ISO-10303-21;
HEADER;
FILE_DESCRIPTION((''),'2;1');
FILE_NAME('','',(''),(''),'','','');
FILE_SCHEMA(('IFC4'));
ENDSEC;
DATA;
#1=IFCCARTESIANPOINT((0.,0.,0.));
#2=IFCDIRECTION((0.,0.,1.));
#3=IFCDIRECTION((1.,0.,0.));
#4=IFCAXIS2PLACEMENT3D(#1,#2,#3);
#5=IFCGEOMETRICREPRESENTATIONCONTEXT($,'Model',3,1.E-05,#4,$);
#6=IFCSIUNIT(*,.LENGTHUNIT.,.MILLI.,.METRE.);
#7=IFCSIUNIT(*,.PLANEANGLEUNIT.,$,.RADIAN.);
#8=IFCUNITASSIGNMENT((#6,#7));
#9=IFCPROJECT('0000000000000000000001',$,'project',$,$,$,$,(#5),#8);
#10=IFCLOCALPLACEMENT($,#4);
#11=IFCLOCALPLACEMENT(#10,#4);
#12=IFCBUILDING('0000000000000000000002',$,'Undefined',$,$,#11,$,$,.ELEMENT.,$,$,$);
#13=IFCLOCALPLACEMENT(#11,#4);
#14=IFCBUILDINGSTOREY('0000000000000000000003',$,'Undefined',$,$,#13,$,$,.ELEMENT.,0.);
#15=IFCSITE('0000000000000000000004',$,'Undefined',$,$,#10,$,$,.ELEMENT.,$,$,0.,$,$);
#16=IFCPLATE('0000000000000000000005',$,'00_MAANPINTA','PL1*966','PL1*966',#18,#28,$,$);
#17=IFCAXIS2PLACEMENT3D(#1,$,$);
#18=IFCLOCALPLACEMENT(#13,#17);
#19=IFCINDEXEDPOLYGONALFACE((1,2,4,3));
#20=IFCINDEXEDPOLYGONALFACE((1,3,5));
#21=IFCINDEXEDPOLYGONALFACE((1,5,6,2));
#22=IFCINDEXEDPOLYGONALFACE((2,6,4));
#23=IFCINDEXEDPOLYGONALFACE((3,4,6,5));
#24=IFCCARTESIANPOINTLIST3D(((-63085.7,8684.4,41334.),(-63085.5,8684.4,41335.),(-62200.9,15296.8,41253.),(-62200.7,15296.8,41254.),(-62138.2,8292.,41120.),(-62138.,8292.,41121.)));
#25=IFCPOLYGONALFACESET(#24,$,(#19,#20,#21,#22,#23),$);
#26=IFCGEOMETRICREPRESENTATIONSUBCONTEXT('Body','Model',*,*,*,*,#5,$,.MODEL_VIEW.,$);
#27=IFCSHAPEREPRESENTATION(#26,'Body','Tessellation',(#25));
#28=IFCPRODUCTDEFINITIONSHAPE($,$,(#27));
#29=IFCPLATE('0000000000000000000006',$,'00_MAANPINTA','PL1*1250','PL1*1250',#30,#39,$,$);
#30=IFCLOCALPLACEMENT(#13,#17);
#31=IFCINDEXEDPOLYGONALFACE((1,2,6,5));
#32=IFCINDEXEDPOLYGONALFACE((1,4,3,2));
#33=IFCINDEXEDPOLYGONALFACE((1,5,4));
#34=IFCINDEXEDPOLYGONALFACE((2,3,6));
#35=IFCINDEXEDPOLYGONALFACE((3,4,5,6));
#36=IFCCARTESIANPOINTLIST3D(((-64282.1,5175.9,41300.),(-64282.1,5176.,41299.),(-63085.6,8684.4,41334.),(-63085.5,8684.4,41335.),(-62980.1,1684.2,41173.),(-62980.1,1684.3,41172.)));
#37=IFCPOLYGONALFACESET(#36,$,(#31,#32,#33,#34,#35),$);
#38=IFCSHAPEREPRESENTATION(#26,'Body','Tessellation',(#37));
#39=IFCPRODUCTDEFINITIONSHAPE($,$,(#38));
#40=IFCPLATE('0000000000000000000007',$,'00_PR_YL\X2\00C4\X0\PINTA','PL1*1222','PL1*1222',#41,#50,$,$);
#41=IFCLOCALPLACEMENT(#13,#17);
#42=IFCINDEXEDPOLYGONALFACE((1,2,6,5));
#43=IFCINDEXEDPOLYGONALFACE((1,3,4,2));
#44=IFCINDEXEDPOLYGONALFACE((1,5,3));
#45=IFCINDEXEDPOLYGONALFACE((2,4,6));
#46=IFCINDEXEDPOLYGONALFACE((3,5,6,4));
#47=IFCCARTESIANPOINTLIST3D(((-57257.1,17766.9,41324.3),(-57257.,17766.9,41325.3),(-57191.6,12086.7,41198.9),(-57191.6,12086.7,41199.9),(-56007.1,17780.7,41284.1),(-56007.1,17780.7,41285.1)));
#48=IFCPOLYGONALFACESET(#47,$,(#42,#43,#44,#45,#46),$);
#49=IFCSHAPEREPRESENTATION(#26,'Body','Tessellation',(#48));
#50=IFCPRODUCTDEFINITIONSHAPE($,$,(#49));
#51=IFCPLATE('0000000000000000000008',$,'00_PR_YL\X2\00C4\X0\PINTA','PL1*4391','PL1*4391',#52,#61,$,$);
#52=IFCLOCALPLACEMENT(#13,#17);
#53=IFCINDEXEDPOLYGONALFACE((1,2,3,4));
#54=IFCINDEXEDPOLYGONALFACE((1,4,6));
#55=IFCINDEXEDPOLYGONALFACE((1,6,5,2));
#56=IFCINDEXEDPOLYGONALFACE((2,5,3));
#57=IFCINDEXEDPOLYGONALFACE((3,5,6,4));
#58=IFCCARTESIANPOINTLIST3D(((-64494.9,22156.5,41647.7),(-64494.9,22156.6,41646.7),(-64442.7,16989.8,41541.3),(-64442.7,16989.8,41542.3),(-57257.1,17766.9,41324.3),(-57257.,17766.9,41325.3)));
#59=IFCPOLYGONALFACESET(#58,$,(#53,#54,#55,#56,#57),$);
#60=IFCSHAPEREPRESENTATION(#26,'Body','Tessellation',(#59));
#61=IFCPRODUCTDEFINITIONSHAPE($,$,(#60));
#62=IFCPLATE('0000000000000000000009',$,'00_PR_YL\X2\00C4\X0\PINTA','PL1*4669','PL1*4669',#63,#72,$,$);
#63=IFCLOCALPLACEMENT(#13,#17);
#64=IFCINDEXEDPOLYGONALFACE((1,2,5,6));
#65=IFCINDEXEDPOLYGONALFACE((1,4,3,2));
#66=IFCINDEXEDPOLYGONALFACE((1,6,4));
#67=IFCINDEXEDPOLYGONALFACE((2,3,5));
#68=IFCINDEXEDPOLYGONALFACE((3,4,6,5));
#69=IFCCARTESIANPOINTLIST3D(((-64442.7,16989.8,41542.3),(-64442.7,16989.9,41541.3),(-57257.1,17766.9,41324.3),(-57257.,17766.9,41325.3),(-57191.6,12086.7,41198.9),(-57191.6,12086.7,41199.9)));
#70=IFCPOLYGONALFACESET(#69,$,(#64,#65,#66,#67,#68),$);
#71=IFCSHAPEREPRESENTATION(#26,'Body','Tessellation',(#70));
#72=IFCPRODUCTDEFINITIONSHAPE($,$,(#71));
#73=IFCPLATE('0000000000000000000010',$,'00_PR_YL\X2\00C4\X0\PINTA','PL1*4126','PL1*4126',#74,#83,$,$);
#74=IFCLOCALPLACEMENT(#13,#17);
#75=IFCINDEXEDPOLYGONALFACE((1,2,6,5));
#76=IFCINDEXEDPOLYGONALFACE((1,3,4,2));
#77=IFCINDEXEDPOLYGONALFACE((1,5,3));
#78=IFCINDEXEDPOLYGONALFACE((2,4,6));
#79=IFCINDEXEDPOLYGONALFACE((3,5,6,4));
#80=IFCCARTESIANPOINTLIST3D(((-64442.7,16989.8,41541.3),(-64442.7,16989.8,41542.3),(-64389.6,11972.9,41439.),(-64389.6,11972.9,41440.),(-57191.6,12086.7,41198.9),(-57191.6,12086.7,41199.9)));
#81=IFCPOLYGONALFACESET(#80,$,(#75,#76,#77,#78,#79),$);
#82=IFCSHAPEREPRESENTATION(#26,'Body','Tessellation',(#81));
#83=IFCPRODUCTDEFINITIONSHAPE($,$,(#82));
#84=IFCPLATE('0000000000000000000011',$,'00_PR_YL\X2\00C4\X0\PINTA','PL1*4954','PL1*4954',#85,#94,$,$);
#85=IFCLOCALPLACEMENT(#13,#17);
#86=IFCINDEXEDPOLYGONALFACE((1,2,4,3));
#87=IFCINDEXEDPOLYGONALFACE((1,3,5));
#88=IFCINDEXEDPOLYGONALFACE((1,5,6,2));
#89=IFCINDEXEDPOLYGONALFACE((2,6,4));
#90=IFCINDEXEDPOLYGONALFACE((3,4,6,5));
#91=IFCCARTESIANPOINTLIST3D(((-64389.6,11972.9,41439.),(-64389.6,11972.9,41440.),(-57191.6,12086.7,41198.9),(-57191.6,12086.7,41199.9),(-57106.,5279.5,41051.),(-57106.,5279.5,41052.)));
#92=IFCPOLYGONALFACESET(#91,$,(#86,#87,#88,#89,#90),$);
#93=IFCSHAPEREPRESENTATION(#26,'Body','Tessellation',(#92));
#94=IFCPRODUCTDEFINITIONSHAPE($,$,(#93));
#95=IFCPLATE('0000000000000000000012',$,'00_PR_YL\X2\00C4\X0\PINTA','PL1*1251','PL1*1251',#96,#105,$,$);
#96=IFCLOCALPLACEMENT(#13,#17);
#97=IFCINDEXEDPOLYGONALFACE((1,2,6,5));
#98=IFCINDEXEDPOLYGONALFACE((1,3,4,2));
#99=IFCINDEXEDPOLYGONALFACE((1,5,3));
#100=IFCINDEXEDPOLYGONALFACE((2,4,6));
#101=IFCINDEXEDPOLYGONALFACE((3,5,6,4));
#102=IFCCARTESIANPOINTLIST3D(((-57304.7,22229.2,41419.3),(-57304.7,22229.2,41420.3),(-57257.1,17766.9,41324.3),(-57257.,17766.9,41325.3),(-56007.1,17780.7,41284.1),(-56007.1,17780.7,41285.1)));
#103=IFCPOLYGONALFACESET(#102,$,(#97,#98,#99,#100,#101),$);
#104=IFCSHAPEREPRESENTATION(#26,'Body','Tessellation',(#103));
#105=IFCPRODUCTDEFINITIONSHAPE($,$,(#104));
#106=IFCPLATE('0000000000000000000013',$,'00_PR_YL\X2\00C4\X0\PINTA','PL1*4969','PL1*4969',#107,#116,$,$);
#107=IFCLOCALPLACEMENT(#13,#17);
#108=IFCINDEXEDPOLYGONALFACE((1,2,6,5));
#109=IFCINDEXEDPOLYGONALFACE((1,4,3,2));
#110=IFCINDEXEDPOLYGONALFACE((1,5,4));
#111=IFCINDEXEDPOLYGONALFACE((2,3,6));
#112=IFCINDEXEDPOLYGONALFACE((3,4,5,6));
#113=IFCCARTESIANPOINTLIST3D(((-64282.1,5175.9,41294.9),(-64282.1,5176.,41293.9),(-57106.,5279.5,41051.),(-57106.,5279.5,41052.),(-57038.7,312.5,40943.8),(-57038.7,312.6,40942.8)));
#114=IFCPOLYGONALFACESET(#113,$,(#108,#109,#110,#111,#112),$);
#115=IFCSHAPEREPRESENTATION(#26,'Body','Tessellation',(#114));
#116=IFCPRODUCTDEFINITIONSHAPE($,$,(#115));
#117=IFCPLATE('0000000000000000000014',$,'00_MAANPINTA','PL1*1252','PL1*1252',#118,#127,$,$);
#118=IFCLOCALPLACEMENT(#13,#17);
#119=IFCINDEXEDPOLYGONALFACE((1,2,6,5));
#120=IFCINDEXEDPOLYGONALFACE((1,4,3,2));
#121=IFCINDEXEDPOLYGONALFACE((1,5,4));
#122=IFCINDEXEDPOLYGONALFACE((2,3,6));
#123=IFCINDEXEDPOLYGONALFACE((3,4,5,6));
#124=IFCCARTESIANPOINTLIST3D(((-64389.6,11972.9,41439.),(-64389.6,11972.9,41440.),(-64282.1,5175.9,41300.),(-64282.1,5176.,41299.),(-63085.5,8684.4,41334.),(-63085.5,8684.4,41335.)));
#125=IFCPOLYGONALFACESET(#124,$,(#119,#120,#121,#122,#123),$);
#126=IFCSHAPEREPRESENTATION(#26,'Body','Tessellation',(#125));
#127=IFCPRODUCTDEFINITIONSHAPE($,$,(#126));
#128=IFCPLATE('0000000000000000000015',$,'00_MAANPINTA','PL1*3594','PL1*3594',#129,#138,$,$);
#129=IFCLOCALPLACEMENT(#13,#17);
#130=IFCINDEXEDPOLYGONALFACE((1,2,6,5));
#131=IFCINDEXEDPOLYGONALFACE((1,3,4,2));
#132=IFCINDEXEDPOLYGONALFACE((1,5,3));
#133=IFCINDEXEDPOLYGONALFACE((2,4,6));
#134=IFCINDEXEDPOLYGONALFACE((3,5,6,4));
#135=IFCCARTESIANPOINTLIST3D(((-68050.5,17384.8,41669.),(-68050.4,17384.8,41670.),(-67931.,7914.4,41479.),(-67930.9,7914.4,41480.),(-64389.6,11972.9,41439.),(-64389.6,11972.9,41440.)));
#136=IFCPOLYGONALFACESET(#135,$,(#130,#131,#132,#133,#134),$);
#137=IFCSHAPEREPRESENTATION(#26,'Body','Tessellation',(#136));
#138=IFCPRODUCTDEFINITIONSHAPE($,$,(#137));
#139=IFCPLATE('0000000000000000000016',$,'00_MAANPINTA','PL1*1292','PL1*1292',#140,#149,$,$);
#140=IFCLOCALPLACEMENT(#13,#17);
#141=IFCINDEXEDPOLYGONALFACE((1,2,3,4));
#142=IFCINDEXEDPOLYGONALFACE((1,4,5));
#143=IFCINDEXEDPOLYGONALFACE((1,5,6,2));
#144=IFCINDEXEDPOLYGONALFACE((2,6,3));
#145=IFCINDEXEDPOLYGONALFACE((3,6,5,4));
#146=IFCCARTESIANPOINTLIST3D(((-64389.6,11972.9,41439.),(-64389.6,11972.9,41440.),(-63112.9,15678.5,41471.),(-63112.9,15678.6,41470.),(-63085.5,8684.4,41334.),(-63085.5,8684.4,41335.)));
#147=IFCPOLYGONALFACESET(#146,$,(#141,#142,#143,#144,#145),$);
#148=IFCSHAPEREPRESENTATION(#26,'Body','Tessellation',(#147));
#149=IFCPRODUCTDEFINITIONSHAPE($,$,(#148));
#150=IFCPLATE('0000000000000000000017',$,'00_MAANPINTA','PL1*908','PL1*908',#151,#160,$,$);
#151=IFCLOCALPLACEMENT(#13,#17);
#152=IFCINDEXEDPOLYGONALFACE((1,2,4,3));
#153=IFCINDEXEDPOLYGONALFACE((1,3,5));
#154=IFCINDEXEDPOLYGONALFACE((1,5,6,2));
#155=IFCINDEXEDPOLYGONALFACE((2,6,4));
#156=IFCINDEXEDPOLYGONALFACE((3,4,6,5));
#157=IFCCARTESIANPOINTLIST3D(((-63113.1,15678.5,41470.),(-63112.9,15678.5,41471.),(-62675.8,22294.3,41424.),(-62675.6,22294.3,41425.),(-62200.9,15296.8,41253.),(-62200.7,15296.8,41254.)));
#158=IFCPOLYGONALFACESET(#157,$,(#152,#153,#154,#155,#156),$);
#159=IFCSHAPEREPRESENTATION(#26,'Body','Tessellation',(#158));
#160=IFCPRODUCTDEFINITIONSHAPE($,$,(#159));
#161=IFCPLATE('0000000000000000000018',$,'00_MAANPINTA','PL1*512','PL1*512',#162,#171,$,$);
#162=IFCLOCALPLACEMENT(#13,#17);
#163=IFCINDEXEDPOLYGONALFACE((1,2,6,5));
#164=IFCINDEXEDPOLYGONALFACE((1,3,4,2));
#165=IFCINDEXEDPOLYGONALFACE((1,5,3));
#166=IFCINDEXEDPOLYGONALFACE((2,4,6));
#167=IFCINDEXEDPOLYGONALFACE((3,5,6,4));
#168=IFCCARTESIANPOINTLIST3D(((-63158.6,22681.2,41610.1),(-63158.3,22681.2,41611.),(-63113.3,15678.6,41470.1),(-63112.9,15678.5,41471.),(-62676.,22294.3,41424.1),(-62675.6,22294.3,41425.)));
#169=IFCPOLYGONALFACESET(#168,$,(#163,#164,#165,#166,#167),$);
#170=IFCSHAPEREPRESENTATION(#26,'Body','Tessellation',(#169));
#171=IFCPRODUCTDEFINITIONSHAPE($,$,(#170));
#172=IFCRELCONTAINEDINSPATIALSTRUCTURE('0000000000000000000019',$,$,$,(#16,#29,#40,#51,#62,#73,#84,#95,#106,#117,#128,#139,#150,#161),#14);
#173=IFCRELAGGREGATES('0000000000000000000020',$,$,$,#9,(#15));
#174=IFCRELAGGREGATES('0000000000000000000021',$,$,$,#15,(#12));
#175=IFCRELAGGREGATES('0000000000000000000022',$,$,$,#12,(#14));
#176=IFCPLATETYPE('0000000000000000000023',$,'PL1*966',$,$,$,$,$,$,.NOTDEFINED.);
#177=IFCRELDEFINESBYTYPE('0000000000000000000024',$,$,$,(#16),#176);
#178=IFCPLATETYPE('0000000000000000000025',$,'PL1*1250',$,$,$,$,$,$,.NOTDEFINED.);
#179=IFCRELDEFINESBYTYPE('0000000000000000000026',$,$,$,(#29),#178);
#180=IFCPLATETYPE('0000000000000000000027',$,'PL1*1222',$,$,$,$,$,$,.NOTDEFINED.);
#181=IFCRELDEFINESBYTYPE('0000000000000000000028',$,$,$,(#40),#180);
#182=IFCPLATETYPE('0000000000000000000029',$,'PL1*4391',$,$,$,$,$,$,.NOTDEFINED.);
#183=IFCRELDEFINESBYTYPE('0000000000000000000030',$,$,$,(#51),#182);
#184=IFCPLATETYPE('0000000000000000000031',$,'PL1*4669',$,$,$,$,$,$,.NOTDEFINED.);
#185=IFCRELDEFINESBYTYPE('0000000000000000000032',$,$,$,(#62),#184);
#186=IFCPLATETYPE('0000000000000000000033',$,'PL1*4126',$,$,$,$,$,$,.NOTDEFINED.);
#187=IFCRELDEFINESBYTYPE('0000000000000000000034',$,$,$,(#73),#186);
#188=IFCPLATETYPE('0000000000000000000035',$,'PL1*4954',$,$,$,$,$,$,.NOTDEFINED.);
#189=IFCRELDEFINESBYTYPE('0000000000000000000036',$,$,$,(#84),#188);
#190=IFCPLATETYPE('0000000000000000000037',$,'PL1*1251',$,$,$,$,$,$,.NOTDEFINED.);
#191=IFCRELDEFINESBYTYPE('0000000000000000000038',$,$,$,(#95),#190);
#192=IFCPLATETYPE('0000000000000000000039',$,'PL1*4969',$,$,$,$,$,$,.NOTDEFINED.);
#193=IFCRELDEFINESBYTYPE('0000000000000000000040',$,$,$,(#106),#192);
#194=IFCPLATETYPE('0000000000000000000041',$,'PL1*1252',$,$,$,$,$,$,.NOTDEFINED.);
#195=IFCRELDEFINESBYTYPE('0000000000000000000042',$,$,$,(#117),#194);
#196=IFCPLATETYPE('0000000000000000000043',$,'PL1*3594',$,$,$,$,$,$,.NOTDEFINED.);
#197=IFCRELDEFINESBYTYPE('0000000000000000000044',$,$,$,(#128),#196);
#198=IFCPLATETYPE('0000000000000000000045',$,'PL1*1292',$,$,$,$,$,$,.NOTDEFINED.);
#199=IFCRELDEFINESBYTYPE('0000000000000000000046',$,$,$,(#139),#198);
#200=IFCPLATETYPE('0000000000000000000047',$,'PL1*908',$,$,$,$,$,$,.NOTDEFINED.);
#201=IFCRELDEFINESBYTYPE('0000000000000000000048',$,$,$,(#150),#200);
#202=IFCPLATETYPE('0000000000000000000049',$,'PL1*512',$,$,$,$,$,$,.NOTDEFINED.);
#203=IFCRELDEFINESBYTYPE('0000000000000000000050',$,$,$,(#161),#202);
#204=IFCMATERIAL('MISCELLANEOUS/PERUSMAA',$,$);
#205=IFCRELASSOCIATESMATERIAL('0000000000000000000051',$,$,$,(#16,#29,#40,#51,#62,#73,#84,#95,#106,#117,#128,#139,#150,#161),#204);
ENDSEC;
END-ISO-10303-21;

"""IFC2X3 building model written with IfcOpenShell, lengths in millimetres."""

from ifc_helpers import new_model, si_unit, frame, origin_with_axes, place, context, subcontext, project, spatial, polyline, outline, extrude, material, type_object, element, save


model = new_model("IFC2X3")

# Units and contexts
model_context = context("Model", 3, precision=1e-05, world=origin_with_axes())
body_context = subcontext(model_context, "Body", "Model", "MODEL_VIEW")
ifc_project = project(units=[si_unit("LENGTHUNIT", "METRE", prefix="MILLI"), si_unit("PLANEANGLEUNIT", "RADIAN")], contexts=[model_context])

# Site, building, storey
site_placement = place(None, origin_with_axes())
site = spatial("IfcSite", under=ifc_project, at=site_placement, Name="Undefined", CompositionType="ELEMENT", RefElevation=0.0)
building_placement = place(site_placement, origin_with_axes())
building = spatial("IfcBuilding", under=site, at=building_placement, Name="Undefined", CompositionType="ELEMENT")
storey_placement = place(building_placement, origin_with_axes())
storey = spatial("IfcBuildingStorey", under=building, at=storey_placement, Name="Undefined", CompositionType="ELEMENT", Elevation=0.0)

# Plates
ifc_material = material(Name="MISCELLANEOUS/PERUSMAA")
plate_type_1 = type_object("IfcPlateType", Name="PL1*966", PredefinedType="NOTDEFINED")
plate_1_placement = place(storey_placement, frame((-62138.1, 8292.0, 41120.5), z_axis=(-0.213706, 0.016633, -0.976757), x_axis=(-0.904445, 0.374508, 0.204262)))
element("IfcPlate", 1, at=plate_1_placement, inside=storey, type_object=plate_type_1, material=ifc_material, Name="00_MAANPINTA", Description="PL1*966", ObjectType="PL1*966", context=body_context, shape_type="SweptSolid", body=[
    extrude(outline(polyline([(0.0, 0.0), (1047.7, 0.0), (2707.2, 6462.2), (0.0, 0.0)])), frame((0.0, 0.0, -0.5), z_axis=(0.0, 0.0, 1.0), x_axis=(1.0, 0.0, 0.0)), (0.0, 0.0, 1.0), 1.0),
])
plate_type_2 = type_object("IfcPlateType", Name="PL1*1250", PredefinedType="NOTDEFINED")
plate_2_placement = place(storey_placement, frame((-63085.5, 8684.4, 41334.5), z_axis=(-0.036937, 0.022564, -0.999063), x_axis=(0.01506, -0.999619, -0.023134)))
element("IfcPlate", 2, at=plate_2_placement, inside=storey, type_object=plate_type_2, material=ifc_material, Name="00_MAANPINTA", Description="PL1*1250", ObjectType="PL1*1250", context=body_context, shape_type="SweptSolid", body=[
    extrude(outline(polyline([(0.0, 0.0), (7002.8, 0.0), (3489.9, 1250.1), (0.0, 0.0)])), frame((0.0, 0.0, -0.5), z_axis=(0.0, 0.0, 1.0), x_axis=(1.0, 0.0, 0.0)), (0.0, 0.0, 1.0), 1.0),
])
plate_type_3 = type_object("IfcPlateType", Name="PL1*1222", PredefinedType="NOTDEFINED")
plate_3_placement = place(storey_placement, frame((-57191.6, 12086.7, 41199.4), z_axis=(-0.032376, 0.021699, -0.99924), x_axis=(-0.011522, 0.99969, 0.022083)))
element("IfcPlate", 3, at=plate_3_placement, inside=storey, type_object=plate_type_3, material=ifc_material, Name="00_PR_YLÄPINTA", Description="PL1*1222", ObjectType="PL1*1222", context=body_context, shape_type="SweptSolid", body=[
    extrude(outline(polyline([(0.0, 0.0), (5681.9, 0.0), (5680.4, 1250.6), (0.0, 0.0)])), frame((0.0, 0.0, -0.5), z_axis=(0.0, 0.0, 1.0), x_axis=(1.0, 0.0, 0.0)), (0.0, 0.0, 1.0), 1.0),
])
plate_type_4 = type_object("IfcPlateType", Name="PL1*4391", PredefinedType="NOTDEFINED")
plate_4_placement = place(storey_placement, frame((-57257.1, 17766.9, 41324.8), z_axis=(-0.032346, 0.020058, -0.999275), x_axis=(-0.993756, -0.107462, 0.03001)))
element("IfcPlate", 4, at=plate_4_placement, inside=storey, type_object=plate_type_4, material=ifc_material, Name="00_PR_YLÄPINTA", Description="PL1*4391", ObjectType="PL1*4391", context=body_context, shape_type="SweptSolid", body=[
    extrude(outline(polyline([(0.0, 0.0), (7230.8, 0.0), (6730.6, 5143.8), (0.0, 0.0)])), frame((0.0, 0.0, -0.5), z_axis=(0.0, 0.0, 1.0), x_axis=(1.0, 0.0, 0.0)), (0.0, 0.0, 1.0), 1.0),
])
plate_type_5 = type_object("IfcPlateType", Name="PL1*4669", PredefinedType="NOTDEFINED")
plate_5_placement = place(storey_placement, frame((-64442.7, 16989.8, 41541.8), z_axis=(-0.032522, 0.021698, -0.999235), x_axis=(0.993756, 0.107462, -0.03001)))
element("IfcPlate", 5, at=plate_5_placement, inside=storey, type_object=plate_type_5, material=ifc_material, Name="00_PR_YLÄPINTA", Description="PL1*4669", ObjectType="PL1*4669", context=body_context, shape_type="SweptSolid", body=[
    extrude(outline(polyline([(0.0, 0.0), (7230.8, 0.0), (6689.2, 5656.0), (0.0, 0.0)])), frame((0.0, 0.0, -0.5), z_axis=(0.0, 0.0, 1.0), x_axis=(1.0, 0.0, 0.0)), (0.0, 0.0, 1.0), 1.0),
])
plate_type_6 = type_object("IfcPlateType", Name="PL1*4126", PredefinedType="NOTDEFINED")
plate_6_placement = place(storey_placement, frame((-57191.6, 12086.7, 41199.4), z_axis=(-0.033651, 0.020027, -0.999233), x_axis=(-0.999319, -0.015802, 0.033337)))
element("IfcPlate", 6, at=plate_6_placement, inside=storey, type_object=plate_type_6, material=ifc_material, Name="00_PR_YLÄPINTA", Description="PL1*4126", ObjectType="PL1*4126", context=body_context, shape_type="SweptSolid", body=[
    extrude(outline(polyline([(0.0, 0.0), (7202.9, 0.0), (7180.1, 5018.2), (0.0, 0.0)])), frame((0.0, 0.0, -0.5), z_axis=(0.0, 0.0, 1.0), x_axis=(1.0, 0.0, 0.0)), (0.0, 0.0, 1.0), 1.0),
])
plate_type_7 = type_object("IfcPlateType", Name="PL1*4954", PredefinedType="NOTDEFINED")
plate_7_placement = place(storey_placement, frame((-64389.6, 11972.9, 41439.5), z_axis=(-0.03367, 0.021284, -0.999206), x_axis=(0.999319, 0.015802, -0.033337)))
element("IfcPlate", 7, at=plate_7_placement, inside=storey, type_object=plate_type_7, material=ifc_material, Name="00_PR_YLÄPINTA", Description="PL1*4954", ObjectType="PL1*4954", context=body_context, shape_type="SweptSolid", body=[
    extrude(outline(polyline([(0.0, 0.0), (7202.9, 0.0), (7185.8, 6809.4), (0.0, 0.0)])), frame((0.0, 0.0, -0.5), z_axis=(0.0, 0.0, 1.0), x_axis=(1.0, 0.0, 0.0)), (0.0, 0.0, 1.0), 1.0),
])
plate_type_8 = type_object("IfcPlateType", Name="PL1*1251", PredefinedType="NOTDEFINED")
plate_8_placement = place(storey_placement, frame((-57257.1, 17766.9, 41324.8), z_axis=(-0.032368, 0.020913, -0.999257), x_axis=(-0.010674, 0.999717, 0.021269)))
element("IfcPlate", 8, at=plate_8_placement, inside=storey, type_object=plate_type_8, material=ifc_material, Name="00_PR_YLÄPINTA", Description="PL1*1251", ObjectType="PL1*1251", context=body_context, shape_type="SweptSolid", body=[
    extrude(outline(polyline([(0.0, 0.0), (4463.6, 0.0), (-0.4, 1250.6), (0.0, 0.0)])), frame((0.0, 0.0, -0.5), z_axis=(0.0, 0.0, 1.0), x_axis=(1.0, 0.0, 0.0)), (0.0, 0.0, 1.0), 1.0),
])
plate_type_9 = type_object("IfcPlateType", Name="PL1*4969", PredefinedType="NOTDEFINED")
plate_9_placement = place(storey_placement, frame((-64282.1, 5175.9, 41294.4), z_axis=(-0.034132, 0.021295, -0.99919), x_axis=(0.999324, 0.014417, -0.033829)))
element("IfcPlate", 9, at=plate_9_placement, inside=storey, type_object=plate_type_9, material=ifc_material, Name="00_PR_YLÄPINTA", Description="PL1*4969", ObjectType="PL1*4969", context=body_context, shape_type="SweptSolid", body=[
    extrude(outline(polyline([(0.0, 0.0), (7180.9, 0.0), (7180.3, 4968.6), (0.0, 0.0)])), frame((0.0, 0.0, -0.5), z_axis=(0.0, 0.0, 1.0), x_axis=(1.0, 0.0, 0.0)), (0.0, 0.0, 1.0), 1.0),
])
plate_type_10 = type_object("IfcPlateType", Name="PL1*1252", PredefinedType="NOTDEFINED")
plate_10_placement = place(storey_placement, frame((-64389.6, 11972.9, 41439.5), z_axis=(-0.029744, 0.020114, -0.999355), x_axis=(0.368459, -0.929171, -0.029668)))
element("IfcPlate", 10, at=plate_10_placement, inside=storey, type_object=plate_type_10, material=ifc_material, Name="00_MAANPINTA", Description="PL1*1252", ObjectType="PL1*1252", context=body_context, shape_type="SweptSolid", body=[
    extrude(outline(polyline([(0.0, 0.0), (3539.2, 0.0), (6359.3, 2406.1), (0.0, 0.0)])), frame((0.0, 0.0, -0.5), z_axis=(0.0, 0.0, 1.0), x_axis=(1.0, 0.0, 0.0)), (0.0, 0.0, 1.0), 1.0),
])
plate_type_11 = type_object("IfcPlateType", Name="PL1*3594", PredefinedType="NOTDEFINED")
plate_11_placement = place(storey_placement, frame((-68050.5, 17384.8, 41669.5), z_axis=(-0.033773, 0.019621, -0.999237), x_axis=(0.559951, -0.827778, -0.03518)))
element("IfcPlate", 11, at=plate_11_placement, inside=storey, type_object=plate_type_11, material=ifc_material, Name="00_MAANPINTA", Description="PL1*3594", ObjectType="PL1*3594", context=body_context, shape_type="SweptSolid", body=[
    extrude(outline(polyline([(0.0, 0.0), (6537.8, 0.0), (7913.0, 5208.0), (0.0, 0.0)])), frame((0.0, 0.0, -0.5), z_axis=(0.0, 0.0, 1.0), x_axis=(1.0, 0.0, 0.0)), (0.0, 0.0, 1.0), 1.0),
])
plate_type_12 = type_object("IfcPlateType", Name="PL1*1292", PredefinedType="NOTDEFINED")
plate_12_placement = place(storey_placement, frame((-63112.9, 15678.5, 41470.5), z_axis=(-0.031775, 0.019307, -0.999309), x_axis=(0.003915, -0.999803, -0.019441)))
element("IfcPlate", 12, at=plate_12_placement, inside=storey, type_object=plate_type_12, material=ifc_material, Name="00_MAANPINTA", Description="PL1*1292", ObjectType="PL1*1292", context=body_context, shape_type="SweptSolid", body=[
    extrude(outline(polyline([(0.0, 0.0), (6995.6, 0.0), (3700.5, 1291.8), (0.0, 0.0)])), frame((0.0, 0.0, -0.5), z_axis=(0.0, 0.0, 1.0), x_axis=(1.0, 0.0, 0.0)), (0.0, 0.0, 1.0), 1.0),
])
plate_type_13 = type_object("IfcPlateType", Name="PL1*908", PredefinedType="NOTDEFINED")
plate_13_placement = place(storey_placement, frame((-62200.8, 15296.8, 41253.5), z_axis=(-0.228116, 0.008309, -0.973599), x_axis=(-0.901052, 0.377048, 0.214336)))
element("IfcPlate", 13, at=plate_13_placement, inside=storey, type_object=plate_type_13, material=ifc_material, Name="00_MAANPINTA", Description="PL1*908", ObjectType="PL1*908", context=body_context, shape_type="SweptSolid", body=[
    extrude(outline(polyline([(0.0, 0.0), (1012.4, 0.0), (3103.0, 6292.1), (0.0, 0.0)])), frame((0.0, 0.0, -0.5), z_axis=(0.0, 0.0, 1.0), x_axis=(1.0, 0.0, 0.0)), (0.0, 0.0, 1.0), 1.0),
])
plate_type_14 = type_object("IfcPlateType", Name="PL1*512", PredefinedType="NOTDEFINED")
plate_14_placement = place(storey_placement, frame((-63113.1, 15678.5, 41470.5), z_axis=(-0.348013, 0.016486, -0.937345), x_axis=(-0.006474, 0.999779, 0.019988)))
element("IfcPlate", 14, at=plate_14_placement, inside=storey, type_object=plate_type_14, material=ifc_material, Name="00_MAANPINTA", Description="PL1*512", ObjectType="PL1*512", context=body_context, shape_type="SweptSolid", body=[
    extrude(outline(polyline([(0.0, 0.0), (7004.2, 0.0), (6610.5, 512.1), (0.0, 0.0)])), frame((0.0, 0.0, -0.5), z_axis=(0.0, 0.0, 1.0), x_axis=(1.0, 0.0, 0.0)), (0.0, 0.0, 1.0), 1.0),
])

save(model, "model.ifc")
